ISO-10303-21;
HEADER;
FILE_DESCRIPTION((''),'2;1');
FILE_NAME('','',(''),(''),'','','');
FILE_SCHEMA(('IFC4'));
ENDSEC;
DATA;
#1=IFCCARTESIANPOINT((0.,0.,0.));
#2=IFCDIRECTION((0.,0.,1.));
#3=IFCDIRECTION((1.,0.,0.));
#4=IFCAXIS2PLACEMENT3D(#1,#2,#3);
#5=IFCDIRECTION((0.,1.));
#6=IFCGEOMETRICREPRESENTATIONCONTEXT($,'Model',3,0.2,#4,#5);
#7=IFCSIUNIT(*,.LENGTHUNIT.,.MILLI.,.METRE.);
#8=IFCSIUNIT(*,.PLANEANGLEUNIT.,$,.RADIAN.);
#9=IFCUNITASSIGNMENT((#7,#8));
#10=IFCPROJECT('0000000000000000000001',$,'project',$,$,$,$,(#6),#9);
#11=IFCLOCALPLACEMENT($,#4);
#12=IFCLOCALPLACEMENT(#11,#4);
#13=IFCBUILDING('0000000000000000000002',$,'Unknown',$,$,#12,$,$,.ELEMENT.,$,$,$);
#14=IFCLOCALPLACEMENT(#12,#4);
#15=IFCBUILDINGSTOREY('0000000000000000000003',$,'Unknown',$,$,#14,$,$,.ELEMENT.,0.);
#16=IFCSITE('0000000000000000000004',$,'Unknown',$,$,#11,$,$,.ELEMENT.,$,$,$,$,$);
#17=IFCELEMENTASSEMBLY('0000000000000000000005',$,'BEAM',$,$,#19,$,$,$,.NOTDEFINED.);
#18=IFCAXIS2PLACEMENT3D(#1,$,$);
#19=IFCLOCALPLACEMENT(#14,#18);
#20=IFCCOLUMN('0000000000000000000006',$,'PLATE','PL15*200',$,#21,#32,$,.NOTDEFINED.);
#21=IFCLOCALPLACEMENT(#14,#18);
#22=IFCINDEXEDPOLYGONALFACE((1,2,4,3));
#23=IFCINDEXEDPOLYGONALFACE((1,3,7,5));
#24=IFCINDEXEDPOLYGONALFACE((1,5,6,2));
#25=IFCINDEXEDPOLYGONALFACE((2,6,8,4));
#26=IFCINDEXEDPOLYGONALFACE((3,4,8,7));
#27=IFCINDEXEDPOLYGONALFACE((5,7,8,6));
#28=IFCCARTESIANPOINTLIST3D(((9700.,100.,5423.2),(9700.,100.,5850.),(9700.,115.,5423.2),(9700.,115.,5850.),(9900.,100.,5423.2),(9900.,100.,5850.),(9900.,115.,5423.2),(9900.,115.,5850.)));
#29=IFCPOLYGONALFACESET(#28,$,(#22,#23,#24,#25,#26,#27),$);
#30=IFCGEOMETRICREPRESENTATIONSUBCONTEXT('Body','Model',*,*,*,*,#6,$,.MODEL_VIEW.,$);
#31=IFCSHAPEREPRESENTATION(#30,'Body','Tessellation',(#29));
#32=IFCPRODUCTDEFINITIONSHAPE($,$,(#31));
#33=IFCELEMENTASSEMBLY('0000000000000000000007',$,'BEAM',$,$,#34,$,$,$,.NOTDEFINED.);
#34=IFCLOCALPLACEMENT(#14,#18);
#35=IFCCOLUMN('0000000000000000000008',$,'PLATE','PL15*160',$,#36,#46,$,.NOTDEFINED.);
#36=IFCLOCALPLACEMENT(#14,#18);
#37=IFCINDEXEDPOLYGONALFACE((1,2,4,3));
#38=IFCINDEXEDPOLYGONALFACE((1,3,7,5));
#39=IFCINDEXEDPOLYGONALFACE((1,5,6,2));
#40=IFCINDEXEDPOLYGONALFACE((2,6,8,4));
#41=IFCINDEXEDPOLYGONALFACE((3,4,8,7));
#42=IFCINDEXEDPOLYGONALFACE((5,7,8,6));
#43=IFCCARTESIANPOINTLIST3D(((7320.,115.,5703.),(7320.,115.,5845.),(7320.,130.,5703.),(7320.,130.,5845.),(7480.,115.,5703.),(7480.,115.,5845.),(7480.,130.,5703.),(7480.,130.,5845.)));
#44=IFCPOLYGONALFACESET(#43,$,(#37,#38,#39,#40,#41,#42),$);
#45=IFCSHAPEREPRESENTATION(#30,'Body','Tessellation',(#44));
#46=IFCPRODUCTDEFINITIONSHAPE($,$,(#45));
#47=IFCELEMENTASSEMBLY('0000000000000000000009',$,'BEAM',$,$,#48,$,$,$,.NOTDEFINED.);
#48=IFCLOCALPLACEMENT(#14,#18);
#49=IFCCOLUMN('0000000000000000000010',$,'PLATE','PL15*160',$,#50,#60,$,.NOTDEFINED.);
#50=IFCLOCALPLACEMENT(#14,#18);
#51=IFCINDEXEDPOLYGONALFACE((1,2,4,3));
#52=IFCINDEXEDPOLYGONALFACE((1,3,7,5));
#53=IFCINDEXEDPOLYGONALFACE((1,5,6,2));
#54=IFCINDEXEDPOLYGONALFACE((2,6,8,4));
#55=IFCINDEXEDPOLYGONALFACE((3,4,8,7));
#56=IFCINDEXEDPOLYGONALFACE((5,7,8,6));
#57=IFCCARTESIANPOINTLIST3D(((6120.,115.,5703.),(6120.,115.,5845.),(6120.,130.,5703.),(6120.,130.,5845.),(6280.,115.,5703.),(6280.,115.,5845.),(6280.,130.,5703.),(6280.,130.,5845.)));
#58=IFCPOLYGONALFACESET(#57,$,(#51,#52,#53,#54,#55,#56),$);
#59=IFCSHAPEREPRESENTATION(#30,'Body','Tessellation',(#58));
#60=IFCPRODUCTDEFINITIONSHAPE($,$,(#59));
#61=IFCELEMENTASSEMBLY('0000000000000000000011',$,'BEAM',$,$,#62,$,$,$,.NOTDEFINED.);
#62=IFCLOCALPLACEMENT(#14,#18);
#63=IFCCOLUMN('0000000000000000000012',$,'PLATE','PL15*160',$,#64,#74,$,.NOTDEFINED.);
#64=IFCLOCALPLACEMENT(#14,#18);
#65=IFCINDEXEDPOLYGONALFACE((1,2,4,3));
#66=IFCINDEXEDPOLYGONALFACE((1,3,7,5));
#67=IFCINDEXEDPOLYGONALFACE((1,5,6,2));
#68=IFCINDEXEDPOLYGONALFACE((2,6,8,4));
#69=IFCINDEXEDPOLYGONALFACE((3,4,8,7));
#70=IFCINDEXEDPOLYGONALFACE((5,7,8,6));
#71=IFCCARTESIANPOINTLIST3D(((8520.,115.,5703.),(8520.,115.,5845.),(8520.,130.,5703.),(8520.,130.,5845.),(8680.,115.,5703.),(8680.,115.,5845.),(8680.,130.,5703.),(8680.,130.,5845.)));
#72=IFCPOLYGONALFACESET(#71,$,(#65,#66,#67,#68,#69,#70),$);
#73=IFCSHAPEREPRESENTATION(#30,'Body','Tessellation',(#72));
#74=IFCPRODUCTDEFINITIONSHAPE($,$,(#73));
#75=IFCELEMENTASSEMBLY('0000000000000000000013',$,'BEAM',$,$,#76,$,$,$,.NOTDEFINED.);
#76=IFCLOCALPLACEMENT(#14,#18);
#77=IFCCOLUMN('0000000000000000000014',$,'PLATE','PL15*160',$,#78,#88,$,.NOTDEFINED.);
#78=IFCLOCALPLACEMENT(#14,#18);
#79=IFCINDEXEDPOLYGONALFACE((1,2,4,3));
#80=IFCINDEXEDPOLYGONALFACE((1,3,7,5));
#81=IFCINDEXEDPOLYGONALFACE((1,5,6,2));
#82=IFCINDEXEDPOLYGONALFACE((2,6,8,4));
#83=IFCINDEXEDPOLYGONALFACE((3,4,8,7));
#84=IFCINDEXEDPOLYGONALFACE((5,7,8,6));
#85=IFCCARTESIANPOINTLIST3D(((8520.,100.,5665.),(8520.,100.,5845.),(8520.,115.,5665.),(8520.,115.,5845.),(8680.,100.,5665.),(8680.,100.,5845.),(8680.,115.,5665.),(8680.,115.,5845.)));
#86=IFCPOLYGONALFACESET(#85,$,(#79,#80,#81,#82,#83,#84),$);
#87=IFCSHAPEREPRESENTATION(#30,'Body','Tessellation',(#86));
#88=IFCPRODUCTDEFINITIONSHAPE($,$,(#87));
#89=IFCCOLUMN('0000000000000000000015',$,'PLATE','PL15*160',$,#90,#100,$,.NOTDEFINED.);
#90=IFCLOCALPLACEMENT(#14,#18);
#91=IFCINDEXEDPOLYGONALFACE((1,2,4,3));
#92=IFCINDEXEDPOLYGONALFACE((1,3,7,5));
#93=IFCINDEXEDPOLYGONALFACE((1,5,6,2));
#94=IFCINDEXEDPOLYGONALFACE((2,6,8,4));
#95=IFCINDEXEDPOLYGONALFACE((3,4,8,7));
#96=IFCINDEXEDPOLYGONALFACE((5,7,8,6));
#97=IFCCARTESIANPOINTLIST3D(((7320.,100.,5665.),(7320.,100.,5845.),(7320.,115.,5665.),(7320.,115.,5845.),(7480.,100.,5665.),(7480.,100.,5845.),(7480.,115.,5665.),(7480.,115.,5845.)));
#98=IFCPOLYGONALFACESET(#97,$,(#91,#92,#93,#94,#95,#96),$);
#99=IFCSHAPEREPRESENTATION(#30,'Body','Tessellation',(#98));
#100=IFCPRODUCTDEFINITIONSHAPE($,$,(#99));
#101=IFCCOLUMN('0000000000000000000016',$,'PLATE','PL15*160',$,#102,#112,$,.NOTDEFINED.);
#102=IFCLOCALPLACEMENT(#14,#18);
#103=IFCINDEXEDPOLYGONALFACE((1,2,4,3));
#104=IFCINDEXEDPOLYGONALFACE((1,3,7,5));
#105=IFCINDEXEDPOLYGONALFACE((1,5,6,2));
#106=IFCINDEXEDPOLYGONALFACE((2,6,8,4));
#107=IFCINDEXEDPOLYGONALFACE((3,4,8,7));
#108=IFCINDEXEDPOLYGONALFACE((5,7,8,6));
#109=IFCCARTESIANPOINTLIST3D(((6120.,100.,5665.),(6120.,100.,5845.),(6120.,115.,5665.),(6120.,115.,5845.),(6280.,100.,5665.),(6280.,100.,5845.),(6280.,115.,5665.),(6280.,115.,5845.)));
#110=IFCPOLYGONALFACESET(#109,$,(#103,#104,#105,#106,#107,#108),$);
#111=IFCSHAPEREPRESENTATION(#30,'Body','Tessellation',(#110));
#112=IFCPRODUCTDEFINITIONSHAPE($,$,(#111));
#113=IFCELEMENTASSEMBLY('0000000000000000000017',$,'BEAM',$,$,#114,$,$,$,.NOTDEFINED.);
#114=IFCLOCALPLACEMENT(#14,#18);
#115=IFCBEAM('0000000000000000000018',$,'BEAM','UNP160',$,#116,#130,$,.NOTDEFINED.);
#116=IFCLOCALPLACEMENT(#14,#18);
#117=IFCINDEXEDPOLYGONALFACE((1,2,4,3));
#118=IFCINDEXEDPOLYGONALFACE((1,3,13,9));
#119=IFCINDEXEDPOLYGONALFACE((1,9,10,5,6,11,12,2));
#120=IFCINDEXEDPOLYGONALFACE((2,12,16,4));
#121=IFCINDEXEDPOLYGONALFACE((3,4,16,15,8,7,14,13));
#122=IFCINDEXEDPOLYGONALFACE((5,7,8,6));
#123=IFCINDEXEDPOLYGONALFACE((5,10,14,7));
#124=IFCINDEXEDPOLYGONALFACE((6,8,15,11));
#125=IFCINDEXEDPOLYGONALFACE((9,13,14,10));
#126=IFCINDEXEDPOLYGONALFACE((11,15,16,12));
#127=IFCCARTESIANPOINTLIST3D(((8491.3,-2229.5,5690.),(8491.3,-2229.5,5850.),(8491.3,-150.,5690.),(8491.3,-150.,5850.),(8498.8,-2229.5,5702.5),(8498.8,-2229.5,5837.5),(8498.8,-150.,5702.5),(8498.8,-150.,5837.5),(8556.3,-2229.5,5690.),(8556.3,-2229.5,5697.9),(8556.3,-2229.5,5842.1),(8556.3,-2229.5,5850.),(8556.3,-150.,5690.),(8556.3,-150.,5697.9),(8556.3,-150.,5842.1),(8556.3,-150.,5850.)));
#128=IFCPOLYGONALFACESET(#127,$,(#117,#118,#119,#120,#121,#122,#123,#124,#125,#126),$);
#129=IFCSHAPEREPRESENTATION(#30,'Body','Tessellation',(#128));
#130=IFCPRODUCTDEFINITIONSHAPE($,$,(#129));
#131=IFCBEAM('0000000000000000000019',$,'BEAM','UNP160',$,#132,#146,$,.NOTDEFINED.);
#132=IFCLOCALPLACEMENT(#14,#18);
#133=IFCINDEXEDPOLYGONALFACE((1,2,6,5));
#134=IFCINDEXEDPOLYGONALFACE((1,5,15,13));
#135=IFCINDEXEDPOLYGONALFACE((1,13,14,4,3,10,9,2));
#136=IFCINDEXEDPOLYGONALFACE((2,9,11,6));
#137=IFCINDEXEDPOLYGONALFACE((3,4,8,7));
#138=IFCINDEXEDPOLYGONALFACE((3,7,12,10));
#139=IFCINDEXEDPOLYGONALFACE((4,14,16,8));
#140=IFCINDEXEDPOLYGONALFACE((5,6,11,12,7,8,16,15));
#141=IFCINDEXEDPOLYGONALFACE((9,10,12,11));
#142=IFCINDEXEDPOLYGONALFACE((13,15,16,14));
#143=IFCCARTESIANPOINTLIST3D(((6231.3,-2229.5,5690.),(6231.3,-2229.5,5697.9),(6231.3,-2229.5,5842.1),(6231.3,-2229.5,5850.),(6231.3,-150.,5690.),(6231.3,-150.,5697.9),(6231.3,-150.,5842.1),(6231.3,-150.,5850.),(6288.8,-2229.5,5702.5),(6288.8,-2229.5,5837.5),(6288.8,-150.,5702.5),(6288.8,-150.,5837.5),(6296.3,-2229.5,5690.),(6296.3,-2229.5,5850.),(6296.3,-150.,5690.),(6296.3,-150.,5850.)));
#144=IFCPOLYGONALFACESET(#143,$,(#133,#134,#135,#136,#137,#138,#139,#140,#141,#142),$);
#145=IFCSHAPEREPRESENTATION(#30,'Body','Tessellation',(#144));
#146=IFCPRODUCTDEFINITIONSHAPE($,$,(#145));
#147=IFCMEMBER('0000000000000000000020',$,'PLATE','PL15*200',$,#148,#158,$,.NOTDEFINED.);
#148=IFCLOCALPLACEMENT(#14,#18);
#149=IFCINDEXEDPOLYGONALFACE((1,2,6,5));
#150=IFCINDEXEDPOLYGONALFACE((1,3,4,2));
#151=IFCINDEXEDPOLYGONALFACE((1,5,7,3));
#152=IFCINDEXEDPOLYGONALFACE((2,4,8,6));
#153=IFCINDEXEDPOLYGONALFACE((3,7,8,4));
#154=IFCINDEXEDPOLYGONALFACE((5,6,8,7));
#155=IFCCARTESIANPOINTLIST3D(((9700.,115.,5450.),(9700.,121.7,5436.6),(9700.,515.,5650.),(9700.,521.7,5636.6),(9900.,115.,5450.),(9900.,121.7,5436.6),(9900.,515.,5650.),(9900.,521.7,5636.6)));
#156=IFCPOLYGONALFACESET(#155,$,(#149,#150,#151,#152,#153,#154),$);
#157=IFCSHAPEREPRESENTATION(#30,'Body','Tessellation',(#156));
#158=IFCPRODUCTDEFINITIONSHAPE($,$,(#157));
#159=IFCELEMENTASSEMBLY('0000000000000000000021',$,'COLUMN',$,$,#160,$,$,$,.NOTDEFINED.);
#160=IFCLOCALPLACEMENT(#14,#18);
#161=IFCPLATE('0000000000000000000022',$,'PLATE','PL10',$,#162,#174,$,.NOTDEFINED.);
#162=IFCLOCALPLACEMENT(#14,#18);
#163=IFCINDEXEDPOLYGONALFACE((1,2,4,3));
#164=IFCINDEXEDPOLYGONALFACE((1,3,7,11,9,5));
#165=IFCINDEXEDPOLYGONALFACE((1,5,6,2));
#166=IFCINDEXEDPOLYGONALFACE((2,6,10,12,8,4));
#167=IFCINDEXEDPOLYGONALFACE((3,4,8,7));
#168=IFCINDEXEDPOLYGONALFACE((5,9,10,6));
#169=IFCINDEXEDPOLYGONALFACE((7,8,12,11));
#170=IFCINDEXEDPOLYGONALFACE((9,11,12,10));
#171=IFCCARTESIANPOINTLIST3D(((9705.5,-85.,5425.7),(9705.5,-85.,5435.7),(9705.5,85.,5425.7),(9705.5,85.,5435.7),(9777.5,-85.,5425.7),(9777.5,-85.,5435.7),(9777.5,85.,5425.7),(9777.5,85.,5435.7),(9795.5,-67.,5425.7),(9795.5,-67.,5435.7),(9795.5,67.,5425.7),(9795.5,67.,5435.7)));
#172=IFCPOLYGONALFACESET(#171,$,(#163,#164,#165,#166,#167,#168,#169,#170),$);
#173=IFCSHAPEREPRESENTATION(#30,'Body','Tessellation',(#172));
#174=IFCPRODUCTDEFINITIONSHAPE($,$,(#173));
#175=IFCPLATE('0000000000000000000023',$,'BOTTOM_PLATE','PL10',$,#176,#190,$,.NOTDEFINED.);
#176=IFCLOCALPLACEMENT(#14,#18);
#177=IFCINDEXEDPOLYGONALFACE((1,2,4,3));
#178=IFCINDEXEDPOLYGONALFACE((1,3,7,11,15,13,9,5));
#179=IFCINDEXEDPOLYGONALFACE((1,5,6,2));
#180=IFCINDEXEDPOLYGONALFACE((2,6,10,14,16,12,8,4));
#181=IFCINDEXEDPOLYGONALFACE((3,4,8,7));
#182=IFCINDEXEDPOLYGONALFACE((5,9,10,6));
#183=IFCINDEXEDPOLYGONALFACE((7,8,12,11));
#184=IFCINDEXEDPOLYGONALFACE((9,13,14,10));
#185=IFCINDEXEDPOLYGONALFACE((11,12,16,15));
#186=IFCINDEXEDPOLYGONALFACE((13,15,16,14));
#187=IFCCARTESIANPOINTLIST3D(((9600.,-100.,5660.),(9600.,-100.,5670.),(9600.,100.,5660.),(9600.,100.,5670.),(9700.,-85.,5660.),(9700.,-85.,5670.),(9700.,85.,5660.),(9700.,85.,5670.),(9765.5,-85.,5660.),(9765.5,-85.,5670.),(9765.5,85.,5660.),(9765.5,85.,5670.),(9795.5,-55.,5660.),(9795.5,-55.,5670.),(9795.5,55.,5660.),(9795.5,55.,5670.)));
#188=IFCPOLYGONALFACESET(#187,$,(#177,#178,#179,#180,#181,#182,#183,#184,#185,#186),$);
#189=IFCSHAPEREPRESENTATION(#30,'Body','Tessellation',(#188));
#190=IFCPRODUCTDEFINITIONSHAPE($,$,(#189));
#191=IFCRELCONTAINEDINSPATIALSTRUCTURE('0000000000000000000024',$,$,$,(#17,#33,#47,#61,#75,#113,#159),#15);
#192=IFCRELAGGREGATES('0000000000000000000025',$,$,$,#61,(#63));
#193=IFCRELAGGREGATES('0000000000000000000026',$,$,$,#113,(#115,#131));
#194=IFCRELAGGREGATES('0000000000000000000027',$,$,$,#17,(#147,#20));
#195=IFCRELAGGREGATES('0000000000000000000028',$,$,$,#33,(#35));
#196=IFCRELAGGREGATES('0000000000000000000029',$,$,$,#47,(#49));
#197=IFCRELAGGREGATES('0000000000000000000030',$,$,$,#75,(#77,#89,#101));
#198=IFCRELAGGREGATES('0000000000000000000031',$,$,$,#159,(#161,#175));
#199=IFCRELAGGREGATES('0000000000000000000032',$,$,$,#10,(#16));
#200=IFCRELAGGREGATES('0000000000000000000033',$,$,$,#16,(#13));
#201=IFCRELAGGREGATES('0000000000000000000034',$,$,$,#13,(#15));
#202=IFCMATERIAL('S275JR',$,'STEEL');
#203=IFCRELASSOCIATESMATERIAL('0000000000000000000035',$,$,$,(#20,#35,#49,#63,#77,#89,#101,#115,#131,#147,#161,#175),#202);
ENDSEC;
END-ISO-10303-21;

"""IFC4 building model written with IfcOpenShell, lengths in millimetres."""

from ifc_helpers import new_model, si_unit, direction, frame, origin_with_axes, place, context, subcontext, project, spatial, line, indexed_curve, outline, extrude, material, element, aggregate, save


model = new_model("IFC4")

# Units and contexts
model_context = context("Model", 3, precision=0.2, world=origin_with_axes(), true_north=direction((0.0, 1.0)))
body_context = subcontext(model_context, "Body", "Model", "MODEL_VIEW")
ifc_project = project(units=[si_unit("LENGTHUNIT", "METRE", prefix="MILLI"), si_unit("PLANEANGLEUNIT", "RADIAN")], contexts=[model_context])

# Site, building, storey
site_placement = place(None, origin_with_axes())
site = spatial("IfcSite", under=ifc_project, at=site_placement, Name="Unknown", CompositionType="ELEMENT")
building_placement = place(site_placement, origin_with_axes())
building = spatial("IfcBuilding", under=site, at=building_placement, Name="Unknown", CompositionType="ELEMENT")
storey_placement = place(building_placement, origin_with_axes())
storey = spatial("IfcBuildingStorey", under=building, at=storey_placement, Name="Unknown", CompositionType="ELEMENT", Elevation=0.0)

# Shared definitions
ifc_material_1 = material(Name="S275JR", Category="STEEL")

# Element assemblies, columns
assembly_1_placement = place(storey_placement, frame((9800.0, 0.0, 5750.0), z_axis=(1.0, 0.0, 0.0), x_axis=(0.0, 1.0, 0.0)))
assembly_1 = element("IfcElementAssembly", 1, at=assembly_1_placement, inside=storey, Name="BEAM", PredefinedType="NOTDEFINED")
column_1_placement = place(assembly_1_placement, frame((107.5, -326.8, 0.0), z_axis=(1.0, 0.0, 0.0), x_axis=(0.0, 1.0, 0.0)))
column_1 = element("IfcColumn", 2, at=column_1_placement, material=ifc_material_1, Name="PLATE", Description="PL15*200", PredefinedType="NOTDEFINED", context=body_context, shape_type="SolidModel", body=[
    extrude(outline(indexed_curve([(-7.5, -100.0), (7.5, -100.0), (7.5, 100.0), (-7.5, 100.0)], segments=[line(1, 2, 3, 4, 1)])), frame((0.0, 0.0, 0.0), z_axis=(-1.0, 0.0, 0.0), x_axis=(0.0, 0.0, 1.0)), (0.0, -0.000002, -1.0), 426.8),
])
assembly_2_placement = place(storey_placement, frame((7400.0, 3600.0, 5774.0), z_axis=(-1.0, 0.0, 0.0), x_axis=(-0.000002, -1.0, 0.0)))
assembly_2 = element("IfcElementAssembly", 3, at=assembly_2_placement, inside=storey, Name="BEAM", PredefinedType="NOTDEFINED")
column_2_placement = place(assembly_2_placement, frame((3477.5, -71.0, 0.0), z_axis=(-1.0, 0.0, 0.0), x_axis=(0.0, 1.0, 0.0)))
column_2 = element("IfcColumn", 4, at=column_2_placement, material=ifc_material_1, Name="PLATE", Description="PL15*160", PredefinedType="NOTDEFINED", context=body_context, shape_type="SolidModel", body=[
    extrude(outline(indexed_curve([(-7.5, -80.0), (7.5, -80.0), (7.5, 80.0), (-7.5, 80.0)], segments=[line(1, 2, 3, 4, 1)])), frame((0.0, 0.0, 0.0), z_axis=(-1.0, 0.0, 0.0), x_axis=(0.0, 0.0, 1.0)), (0.0, -0.000002, -1.0), 142.0),
])
assembly_3_placement = place(storey_placement, frame((6200.0, 3600.0, 5774.0), z_axis=(-1.0, 0.0, 0.0), x_axis=(-0.000002, -1.0, 0.0)))
assembly_3 = element("IfcElementAssembly", 5, at=assembly_3_placement, inside=storey, Name="BEAM", PredefinedType="NOTDEFINED")
column_3_placement = place(assembly_3_placement, frame((3477.5, -71.0, 0.0), z_axis=(-1.0, 0.0, 0.0), x_axis=(0.0, 1.0, 0.0)))
column_3 = element("IfcColumn", 6, at=column_3_placement, material=ifc_material_1, Name="PLATE", Description="PL15*160", PredefinedType="NOTDEFINED", context=body_context, shape_type="SolidModel", body=[
    extrude(outline(indexed_curve([(-7.5, -80.0), (7.5, -80.0), (7.5, 80.0), (-7.5, 80.0)], segments=[line(1, 2, 3, 4, 1)])), frame((0.0, 0.0, 0.0), z_axis=(-1.0, 0.0, 0.0), x_axis=(0.0, 0.0, 1.0)), (0.0, -0.000002, -1.0), 142.0),
])
assembly_4_placement = place(storey_placement, frame((8600.0, 3600.0, 5774.0), z_axis=(-1.0, 0.0, 0.0), x_axis=(-0.000002, -1.0, 0.0)))
assembly_4 = element("IfcElementAssembly", 7, at=assembly_4_placement, inside=storey, Name="BEAM", PredefinedType="NOTDEFINED")
column_4_placement = place(assembly_4_placement, frame((3477.5, -71.0, 0.0), z_axis=(-1.0, 0.0, 0.0), x_axis=(0.0, 1.0, 0.0)))
column_4 = element("IfcColumn", 8, at=column_4_placement, material=ifc_material_1, Name="PLATE", Description="PL15*160", PredefinedType="NOTDEFINED", context=body_context, shape_type="SolidModel", body=[
    extrude(outline(indexed_curve([(-7.5, -80.0), (7.5, -80.0), (7.5, 80.0), (-7.5, 80.0)], segments=[line(1, 2, 3, 4, 1)])), frame((0.0, 0.0, 0.0), z_axis=(-1.0, 0.0, 0.0), x_axis=(0.0, 0.0, 1.0)), (0.0, -0.000002, -1.0), 142.0),
])
aggregate(assembly_4, [column_4])

# Element assembly, columns
assembly_5_placement = place(storey_placement, frame((9800.0, 0.0, 5755.0), z_axis=(0.0, 1.0, 0.0), x_axis=(-1.0, 0.0, 0.0)))
assembly_5 = element("IfcElementAssembly", 9, at=assembly_5_placement, inside=storey, Name="BEAM", PredefinedType="NOTDEFINED")
column_5_placement = place(assembly_5_placement, frame((1200.0, -90.0, 107.5), z_axis=(0.0, 0.0, 1.0), x_axis=(0.0, 1.0, 0.0)))
column_5 = element("IfcColumn", 10, at=column_5_placement, material=ifc_material_1, Name="PLATE", Description="PL15*160", PredefinedType="NOTDEFINED", context=body_context, shape_type="SolidModel", body=[
    extrude(outline(indexed_curve([(-7.5, -80.0), (7.5, -80.0), (7.5, 80.0), (-7.5, 80.0)], segments=[line(1, 2, 3, 4, 1)])), frame((0.0, 0.0, 0.0), z_axis=(-1.0, 0.0, 0.0), x_axis=(0.0, 0.0, 1.0)), (0.0, -0.000002, -1.0), 180.0),
])
column_6_placement = place(assembly_5_placement, frame((2400.0, -90.0, 107.5), z_axis=(0.0, 0.0, 1.0), x_axis=(0.0, 1.0, 0.0)))
column_6 = element("IfcColumn", 11, at=column_6_placement, material=ifc_material_1, Name="PLATE", Description="PL15*160", PredefinedType="NOTDEFINED", context=body_context, shape_type="SolidModel", body=[
    extrude(outline(indexed_curve([(-7.5, -80.0), (7.5, -80.0), (7.5, 80.0), (-7.5, 80.0)], segments=[line(1, 2, 3, 4, 1)])), frame((0.0, 0.0, 0.0), z_axis=(-1.0, 0.0, 0.0), x_axis=(0.0, 0.0, 1.0)), (0.0, -0.000002, -1.0), 180.0),
])
column_7_placement = place(assembly_5_placement, frame((3600.0, -90.0, 107.5), z_axis=(0.0, 0.0, 1.0), x_axis=(0.0, 1.0, 0.0)))
column_7 = element("IfcColumn", 12, at=column_7_placement, material=ifc_material_1, Name="PLATE", Description="PL15*160", PredefinedType="NOTDEFINED", context=body_context, shape_type="SolidModel", body=[
    extrude(outline(indexed_curve([(-7.5, -80.0), (7.5, -80.0), (7.5, 80.0), (-7.5, 80.0)], segments=[line(1, 2, 3, 4, 1)])), frame((0.0, 0.0, 0.0), z_axis=(-1.0, 0.0, 0.0), x_axis=(0.0, 0.0, 1.0)), (0.0, -0.000002, -1.0), 180.0),
])

# Element assembly, beams
assembly_6_placement = place(storey_placement, frame((6231.3, -2197.0, 5770.0), z_axis=(0.0, -1.0, 0.000002), x_axis=(1.0, 0.0, 0.0)))
assembly_6 = element("IfcElementAssembly", 13, at=assembly_6_placement, inside=storey, Name="BEAM", PredefinedType="NOTDEFINED")
beam_1_placement = place(assembly_6_placement, frame((2292.5, 0.0, -2047.0), z_axis=(1.0, 0.0, 0.0), x_axis=(0.0, 0.0, 1.0)))
beam_1 = element("IfcBeam", 14, at=beam_1_placement, material=ifc_material_1, Name="BEAM", Description="UNP160", PredefinedType="NOTDEFINED", context=body_context, shape_type="SolidModel", body=[
    extrude(outline(indexed_curve([(-32.5, -80.0), (32.5, -80.0), (32.5, -72.1), (-25.0, -67.5), (-25.0, 67.5), (32.5, 72.1), (32.5, 80.0), (-32.5, 80.0)], segments=[line(1, 2, 3, 4, 5, 6, 7, 8, 1)])), frame((0.0, 0.0, 0.0), z_axis=(-1.0, 0.0, 0.0), x_axis=(0.0, 0.0, 1.0)), (0.0, -0.000002, -1.0), 2079.5),
])
beam_2_placement = place(assembly_6_placement, frame((32.5, 0.0, -2047.0), z_axis=(-1.0, 0.0, -0.000011), x_axis=(0.0, 0.0, 1.0)))
beam_2 = element("IfcBeam", 15, at=beam_2_placement, material=ifc_material_1, Name="BEAM", Description="UNP160", PredefinedType="NOTDEFINED", context=body_context, shape_type="SolidModel", body=[
    extrude(outline(indexed_curve([(-32.5, -80.0), (32.5, -80.0), (32.5, -72.1), (-25.0, -67.5), (-25.0, 67.5), (32.5, 72.1), (32.5, 80.0), (-32.5, 80.0)], segments=[line(1, 2, 3, 4, 5, 6, 7, 8, 1)])), frame((0.0, 0.0, 0.0), z_axis=(-1.0, 0.0, 0.0), x_axis=(0.0, 0.0, 1.0)), (0.0, -0.000002, -1.0), 2079.5),
])
aggregate(assembly_6, [beam_1, beam_2])

# Member
member_placement = place(assembly_1_placement, frame((118.4, -306.7, 0.0), z_axis=(0.447214, -0.894427, 0.0), x_axis=(0.894427, 0.447214, 0.0)))
member = element("IfcMember", 16, at=member_placement, material=ifc_material_1, Name="PLATE", Description="PL15*200", PredefinedType="NOTDEFINED", context=body_context, shape_type="SolidModel", body=[
    extrude(outline(indexed_curve([(-7.5, -100.0), (7.5, -100.0), (7.5, 100.0), (-7.5, 100.0)], segments=[line(1, 2, 3, 4, 1)])), frame((0.0, 0.0, 0.0), z_axis=(-1.0, 0.0, 0.0), x_axis=(0.0, 0.0, 1.0)), (0.0, -0.000002, -1.0), 447.2),
])

# Element assembly, plates
assembly_7_placement = place(storey_placement, frame((9800.0, 0.0, 200.0), z_axis=(-1.0, 0.0, 0.0), x_axis=(0.0, 0.0, 1.0)))
assembly_7 = element("IfcElementAssembly", 17, at=assembly_7_placement, inside=storey, Name="COLUMN", PredefinedType="NOTDEFINED")
plate_1_placement = place(assembly_7_placement, frame((5230.7, 85.0, 94.5), z_axis=(-1.0, 0.0, 0.0), x_axis=(0.0, -0.000002, -1.0)))
plate_1 = element("IfcPlate", 18, at=plate_1_placement, material=ifc_material_1, Name="PLATE", Description="PL10", PredefinedType="NOTDEFINED", context=body_context, shape_type="SolidModel", body=[
    extrude(outline(indexed_curve([(0.0, 0.0), (72.0, 0.0), (90.0, 18.0), (90.0, 152.0), (72.0, 170.0), (0.0, 170.0)], segments=[line(1, 2, 3, 4, 5, 6, 1)])), frame((0.0, 0.0, 5.0), z_axis=(0.0, 0.0, 1.0), x_axis=(1.0, 0.0, 0.0)), (0.0, -0.000002, -1.0), 10.0),
])
plate_2_placement = place(assembly_7_placement, frame((5465.0, -85.0, 4.5), z_axis=(1.0, 0.0, 0.0), x_axis=(0.0, 1.0, 0.0)))
plate_2 = element("IfcPlate", 19, at=plate_2_placement, material=ifc_material_1, Name="BOTTOM_PLATE", Description="PL10", PredefinedType="NOTDEFINED", context=body_context, shape_type="SolidModel", body=[
    extrude(outline(indexed_curve([(0.0, 30.0), (30.0, 0.0), (140.0, 0.0), (170.0, 30.0), (170.0, 95.5), (185.0, 195.5), (-15.0, 195.5), (0.0, 95.5)], segments=[line(1, 2, 3, 4, 5, 6, 7, 8, 1)])), frame((0.0, 0.0, 5.0), z_axis=(0.0, 0.0, 1.0), x_axis=(1.0, 0.0, 0.0)), (0.0, -0.000002, -1.0), 10.0),
])

aggregate(assembly_1, [member, column_1])
aggregate(assembly_2, [column_2])
aggregate(assembly_3, [column_3])
aggregate(assembly_5, [column_5, column_6, column_7])

aggregate(assembly_7, [plate_1, plate_2])

save(model, "model.ifc")
